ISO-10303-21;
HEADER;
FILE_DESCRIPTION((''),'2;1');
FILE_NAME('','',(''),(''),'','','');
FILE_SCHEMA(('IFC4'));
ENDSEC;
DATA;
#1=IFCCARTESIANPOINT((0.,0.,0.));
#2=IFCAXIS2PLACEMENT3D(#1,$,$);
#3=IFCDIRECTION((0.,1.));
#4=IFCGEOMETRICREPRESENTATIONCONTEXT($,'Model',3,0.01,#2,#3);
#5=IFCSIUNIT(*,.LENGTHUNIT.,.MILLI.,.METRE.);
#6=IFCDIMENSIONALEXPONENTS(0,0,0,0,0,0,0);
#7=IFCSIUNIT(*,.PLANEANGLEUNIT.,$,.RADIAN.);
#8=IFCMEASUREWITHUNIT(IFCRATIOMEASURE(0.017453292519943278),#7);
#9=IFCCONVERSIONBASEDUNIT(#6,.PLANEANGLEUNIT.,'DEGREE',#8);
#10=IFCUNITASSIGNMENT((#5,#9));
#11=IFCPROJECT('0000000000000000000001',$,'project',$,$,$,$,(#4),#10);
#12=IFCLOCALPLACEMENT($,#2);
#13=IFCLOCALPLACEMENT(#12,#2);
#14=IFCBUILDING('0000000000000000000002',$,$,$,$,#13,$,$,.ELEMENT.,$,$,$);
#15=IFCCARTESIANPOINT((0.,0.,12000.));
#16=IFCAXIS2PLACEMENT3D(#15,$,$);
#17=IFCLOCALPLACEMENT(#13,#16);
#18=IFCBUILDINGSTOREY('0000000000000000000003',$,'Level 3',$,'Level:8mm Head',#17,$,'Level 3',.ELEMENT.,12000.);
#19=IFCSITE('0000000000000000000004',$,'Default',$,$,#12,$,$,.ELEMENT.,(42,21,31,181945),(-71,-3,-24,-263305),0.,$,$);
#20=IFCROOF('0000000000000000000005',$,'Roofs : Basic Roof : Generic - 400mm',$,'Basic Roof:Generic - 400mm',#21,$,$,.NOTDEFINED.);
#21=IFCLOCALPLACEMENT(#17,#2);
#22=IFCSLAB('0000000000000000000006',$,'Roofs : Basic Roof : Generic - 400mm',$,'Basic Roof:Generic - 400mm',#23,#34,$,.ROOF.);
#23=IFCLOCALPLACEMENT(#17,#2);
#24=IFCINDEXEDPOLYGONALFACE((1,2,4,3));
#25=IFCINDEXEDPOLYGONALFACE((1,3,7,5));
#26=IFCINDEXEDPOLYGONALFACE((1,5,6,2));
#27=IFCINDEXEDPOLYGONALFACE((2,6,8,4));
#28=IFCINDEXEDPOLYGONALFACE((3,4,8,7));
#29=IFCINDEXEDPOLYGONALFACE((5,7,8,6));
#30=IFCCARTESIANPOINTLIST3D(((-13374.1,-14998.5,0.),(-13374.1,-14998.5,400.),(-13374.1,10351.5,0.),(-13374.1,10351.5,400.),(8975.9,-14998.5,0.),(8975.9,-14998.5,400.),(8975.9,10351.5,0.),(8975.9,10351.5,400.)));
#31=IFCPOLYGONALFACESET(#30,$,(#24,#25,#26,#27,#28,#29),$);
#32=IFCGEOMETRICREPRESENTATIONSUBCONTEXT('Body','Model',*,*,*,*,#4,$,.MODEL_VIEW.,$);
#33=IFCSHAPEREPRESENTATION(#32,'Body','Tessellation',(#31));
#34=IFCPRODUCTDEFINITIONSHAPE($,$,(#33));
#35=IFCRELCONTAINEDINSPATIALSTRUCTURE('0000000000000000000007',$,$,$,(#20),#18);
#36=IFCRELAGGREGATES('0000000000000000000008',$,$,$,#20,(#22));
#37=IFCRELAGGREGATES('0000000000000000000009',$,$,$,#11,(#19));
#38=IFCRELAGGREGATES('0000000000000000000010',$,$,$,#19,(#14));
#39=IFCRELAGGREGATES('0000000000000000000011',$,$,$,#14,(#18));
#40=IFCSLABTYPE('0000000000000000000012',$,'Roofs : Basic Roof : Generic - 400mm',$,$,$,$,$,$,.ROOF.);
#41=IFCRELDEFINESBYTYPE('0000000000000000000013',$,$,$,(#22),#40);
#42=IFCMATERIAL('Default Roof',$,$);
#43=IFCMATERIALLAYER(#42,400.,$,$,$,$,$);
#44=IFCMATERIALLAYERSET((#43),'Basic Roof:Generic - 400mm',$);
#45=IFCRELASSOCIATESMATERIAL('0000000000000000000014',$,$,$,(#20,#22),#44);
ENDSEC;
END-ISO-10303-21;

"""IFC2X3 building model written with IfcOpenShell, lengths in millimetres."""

from ifc_helpers import new_model, entity, si_unit, converted_unit, direction, frame, frame_2d, origin, place, context, subcontext, project, spatial, rectangle, extrude, material, layer, layer_set, type_object, element, aggregate, save


model = new_model("IFC2X3")

# Units and contexts
model_context = context("Model", 3, precision=0.01, world=origin(), true_north=direction((0.0, 1.0)))
body_context = subcontext(model_context, "Body", "Model", "MODEL_VIEW")
ifc_project = project(units=[si_unit("LENGTHUNIT", "METRE", prefix="MILLI"), converted_unit("PLANEANGLEUNIT", "DEGREE", entity("IfcRatioMeasure", 0.017453292519943278), si_unit("PLANEANGLEUNIT", "RADIAN"), dimensions=[0, 0, 0, 0, 0, 0, 0])], contexts=[model_context])

# Site, building, storey
site_placement = place(None, origin())
site = spatial("IfcSite", under=ifc_project, at=site_placement, Name="Default", CompositionType="ELEMENT", RefLatitude=(42, 21, 31, 181945), RefLongitude=(-71, -3, -24, -263305), RefElevation=0.0)
building_placement = place(site_placement, origin())
building = spatial("IfcBuilding", under=site, at=building_placement, CompositionType="ELEMENT")
storey_placement = place(building_placement, frame((0.0, 0.0, 12000.0)))
storey = spatial("IfcBuildingStorey", under=building, at=storey_placement, Name="Level 3", ObjectType="Level:8mm Head", LongName="Level 3", CompositionType="ELEMENT", Elevation=12000.0)

# Roof, slab
ifc_material = material(Name="Default Roof")
ifc_layer = layer(ifc_material, 400.0)
ifc_layer_set = layer_set([ifc_layer], Name="Basic Roof:Generic - 400mm")
roof_placement = place(storey_placement, frame((-13374.1, -14998.5, 0.0)))
roof = element("IfcRoof", 1, at=roof_placement, inside=storey, material=ifc_layer_set, Name="Roofs : Basic Roof : Generic - 400mm", ObjectType="Basic Roof:Generic - 400mm", ShapeType="NOTDEFINED")
slab_type = type_object("IfcSlabType", Name="Roofs : Basic Roof : Generic - 400mm", PredefinedType="ROOF")
slab_placement = place(roof_placement, origin())
slab = element("IfcSlab", 2, at=slab_placement, type_object=slab_type, material=ifc_layer_set, Name="Roofs : Basic Roof : Generic - 400mm", ObjectType="Basic Roof:Generic - 400mm", PredefinedType="ROOF", context=body_context, shape_type="SweptSolid", body=[
    extrude(rectangle(XDim=22350.0, YDim=25350.0, at=frame_2d((0.0, 0.0), x_axis=(1.0, 0.0))), frame((11175.0, 12675.0, 0.0)), (0.0, 0.0, 1.0), 400.0),
])
aggregate(roof, [slab])

save(model, "model.ifc")
